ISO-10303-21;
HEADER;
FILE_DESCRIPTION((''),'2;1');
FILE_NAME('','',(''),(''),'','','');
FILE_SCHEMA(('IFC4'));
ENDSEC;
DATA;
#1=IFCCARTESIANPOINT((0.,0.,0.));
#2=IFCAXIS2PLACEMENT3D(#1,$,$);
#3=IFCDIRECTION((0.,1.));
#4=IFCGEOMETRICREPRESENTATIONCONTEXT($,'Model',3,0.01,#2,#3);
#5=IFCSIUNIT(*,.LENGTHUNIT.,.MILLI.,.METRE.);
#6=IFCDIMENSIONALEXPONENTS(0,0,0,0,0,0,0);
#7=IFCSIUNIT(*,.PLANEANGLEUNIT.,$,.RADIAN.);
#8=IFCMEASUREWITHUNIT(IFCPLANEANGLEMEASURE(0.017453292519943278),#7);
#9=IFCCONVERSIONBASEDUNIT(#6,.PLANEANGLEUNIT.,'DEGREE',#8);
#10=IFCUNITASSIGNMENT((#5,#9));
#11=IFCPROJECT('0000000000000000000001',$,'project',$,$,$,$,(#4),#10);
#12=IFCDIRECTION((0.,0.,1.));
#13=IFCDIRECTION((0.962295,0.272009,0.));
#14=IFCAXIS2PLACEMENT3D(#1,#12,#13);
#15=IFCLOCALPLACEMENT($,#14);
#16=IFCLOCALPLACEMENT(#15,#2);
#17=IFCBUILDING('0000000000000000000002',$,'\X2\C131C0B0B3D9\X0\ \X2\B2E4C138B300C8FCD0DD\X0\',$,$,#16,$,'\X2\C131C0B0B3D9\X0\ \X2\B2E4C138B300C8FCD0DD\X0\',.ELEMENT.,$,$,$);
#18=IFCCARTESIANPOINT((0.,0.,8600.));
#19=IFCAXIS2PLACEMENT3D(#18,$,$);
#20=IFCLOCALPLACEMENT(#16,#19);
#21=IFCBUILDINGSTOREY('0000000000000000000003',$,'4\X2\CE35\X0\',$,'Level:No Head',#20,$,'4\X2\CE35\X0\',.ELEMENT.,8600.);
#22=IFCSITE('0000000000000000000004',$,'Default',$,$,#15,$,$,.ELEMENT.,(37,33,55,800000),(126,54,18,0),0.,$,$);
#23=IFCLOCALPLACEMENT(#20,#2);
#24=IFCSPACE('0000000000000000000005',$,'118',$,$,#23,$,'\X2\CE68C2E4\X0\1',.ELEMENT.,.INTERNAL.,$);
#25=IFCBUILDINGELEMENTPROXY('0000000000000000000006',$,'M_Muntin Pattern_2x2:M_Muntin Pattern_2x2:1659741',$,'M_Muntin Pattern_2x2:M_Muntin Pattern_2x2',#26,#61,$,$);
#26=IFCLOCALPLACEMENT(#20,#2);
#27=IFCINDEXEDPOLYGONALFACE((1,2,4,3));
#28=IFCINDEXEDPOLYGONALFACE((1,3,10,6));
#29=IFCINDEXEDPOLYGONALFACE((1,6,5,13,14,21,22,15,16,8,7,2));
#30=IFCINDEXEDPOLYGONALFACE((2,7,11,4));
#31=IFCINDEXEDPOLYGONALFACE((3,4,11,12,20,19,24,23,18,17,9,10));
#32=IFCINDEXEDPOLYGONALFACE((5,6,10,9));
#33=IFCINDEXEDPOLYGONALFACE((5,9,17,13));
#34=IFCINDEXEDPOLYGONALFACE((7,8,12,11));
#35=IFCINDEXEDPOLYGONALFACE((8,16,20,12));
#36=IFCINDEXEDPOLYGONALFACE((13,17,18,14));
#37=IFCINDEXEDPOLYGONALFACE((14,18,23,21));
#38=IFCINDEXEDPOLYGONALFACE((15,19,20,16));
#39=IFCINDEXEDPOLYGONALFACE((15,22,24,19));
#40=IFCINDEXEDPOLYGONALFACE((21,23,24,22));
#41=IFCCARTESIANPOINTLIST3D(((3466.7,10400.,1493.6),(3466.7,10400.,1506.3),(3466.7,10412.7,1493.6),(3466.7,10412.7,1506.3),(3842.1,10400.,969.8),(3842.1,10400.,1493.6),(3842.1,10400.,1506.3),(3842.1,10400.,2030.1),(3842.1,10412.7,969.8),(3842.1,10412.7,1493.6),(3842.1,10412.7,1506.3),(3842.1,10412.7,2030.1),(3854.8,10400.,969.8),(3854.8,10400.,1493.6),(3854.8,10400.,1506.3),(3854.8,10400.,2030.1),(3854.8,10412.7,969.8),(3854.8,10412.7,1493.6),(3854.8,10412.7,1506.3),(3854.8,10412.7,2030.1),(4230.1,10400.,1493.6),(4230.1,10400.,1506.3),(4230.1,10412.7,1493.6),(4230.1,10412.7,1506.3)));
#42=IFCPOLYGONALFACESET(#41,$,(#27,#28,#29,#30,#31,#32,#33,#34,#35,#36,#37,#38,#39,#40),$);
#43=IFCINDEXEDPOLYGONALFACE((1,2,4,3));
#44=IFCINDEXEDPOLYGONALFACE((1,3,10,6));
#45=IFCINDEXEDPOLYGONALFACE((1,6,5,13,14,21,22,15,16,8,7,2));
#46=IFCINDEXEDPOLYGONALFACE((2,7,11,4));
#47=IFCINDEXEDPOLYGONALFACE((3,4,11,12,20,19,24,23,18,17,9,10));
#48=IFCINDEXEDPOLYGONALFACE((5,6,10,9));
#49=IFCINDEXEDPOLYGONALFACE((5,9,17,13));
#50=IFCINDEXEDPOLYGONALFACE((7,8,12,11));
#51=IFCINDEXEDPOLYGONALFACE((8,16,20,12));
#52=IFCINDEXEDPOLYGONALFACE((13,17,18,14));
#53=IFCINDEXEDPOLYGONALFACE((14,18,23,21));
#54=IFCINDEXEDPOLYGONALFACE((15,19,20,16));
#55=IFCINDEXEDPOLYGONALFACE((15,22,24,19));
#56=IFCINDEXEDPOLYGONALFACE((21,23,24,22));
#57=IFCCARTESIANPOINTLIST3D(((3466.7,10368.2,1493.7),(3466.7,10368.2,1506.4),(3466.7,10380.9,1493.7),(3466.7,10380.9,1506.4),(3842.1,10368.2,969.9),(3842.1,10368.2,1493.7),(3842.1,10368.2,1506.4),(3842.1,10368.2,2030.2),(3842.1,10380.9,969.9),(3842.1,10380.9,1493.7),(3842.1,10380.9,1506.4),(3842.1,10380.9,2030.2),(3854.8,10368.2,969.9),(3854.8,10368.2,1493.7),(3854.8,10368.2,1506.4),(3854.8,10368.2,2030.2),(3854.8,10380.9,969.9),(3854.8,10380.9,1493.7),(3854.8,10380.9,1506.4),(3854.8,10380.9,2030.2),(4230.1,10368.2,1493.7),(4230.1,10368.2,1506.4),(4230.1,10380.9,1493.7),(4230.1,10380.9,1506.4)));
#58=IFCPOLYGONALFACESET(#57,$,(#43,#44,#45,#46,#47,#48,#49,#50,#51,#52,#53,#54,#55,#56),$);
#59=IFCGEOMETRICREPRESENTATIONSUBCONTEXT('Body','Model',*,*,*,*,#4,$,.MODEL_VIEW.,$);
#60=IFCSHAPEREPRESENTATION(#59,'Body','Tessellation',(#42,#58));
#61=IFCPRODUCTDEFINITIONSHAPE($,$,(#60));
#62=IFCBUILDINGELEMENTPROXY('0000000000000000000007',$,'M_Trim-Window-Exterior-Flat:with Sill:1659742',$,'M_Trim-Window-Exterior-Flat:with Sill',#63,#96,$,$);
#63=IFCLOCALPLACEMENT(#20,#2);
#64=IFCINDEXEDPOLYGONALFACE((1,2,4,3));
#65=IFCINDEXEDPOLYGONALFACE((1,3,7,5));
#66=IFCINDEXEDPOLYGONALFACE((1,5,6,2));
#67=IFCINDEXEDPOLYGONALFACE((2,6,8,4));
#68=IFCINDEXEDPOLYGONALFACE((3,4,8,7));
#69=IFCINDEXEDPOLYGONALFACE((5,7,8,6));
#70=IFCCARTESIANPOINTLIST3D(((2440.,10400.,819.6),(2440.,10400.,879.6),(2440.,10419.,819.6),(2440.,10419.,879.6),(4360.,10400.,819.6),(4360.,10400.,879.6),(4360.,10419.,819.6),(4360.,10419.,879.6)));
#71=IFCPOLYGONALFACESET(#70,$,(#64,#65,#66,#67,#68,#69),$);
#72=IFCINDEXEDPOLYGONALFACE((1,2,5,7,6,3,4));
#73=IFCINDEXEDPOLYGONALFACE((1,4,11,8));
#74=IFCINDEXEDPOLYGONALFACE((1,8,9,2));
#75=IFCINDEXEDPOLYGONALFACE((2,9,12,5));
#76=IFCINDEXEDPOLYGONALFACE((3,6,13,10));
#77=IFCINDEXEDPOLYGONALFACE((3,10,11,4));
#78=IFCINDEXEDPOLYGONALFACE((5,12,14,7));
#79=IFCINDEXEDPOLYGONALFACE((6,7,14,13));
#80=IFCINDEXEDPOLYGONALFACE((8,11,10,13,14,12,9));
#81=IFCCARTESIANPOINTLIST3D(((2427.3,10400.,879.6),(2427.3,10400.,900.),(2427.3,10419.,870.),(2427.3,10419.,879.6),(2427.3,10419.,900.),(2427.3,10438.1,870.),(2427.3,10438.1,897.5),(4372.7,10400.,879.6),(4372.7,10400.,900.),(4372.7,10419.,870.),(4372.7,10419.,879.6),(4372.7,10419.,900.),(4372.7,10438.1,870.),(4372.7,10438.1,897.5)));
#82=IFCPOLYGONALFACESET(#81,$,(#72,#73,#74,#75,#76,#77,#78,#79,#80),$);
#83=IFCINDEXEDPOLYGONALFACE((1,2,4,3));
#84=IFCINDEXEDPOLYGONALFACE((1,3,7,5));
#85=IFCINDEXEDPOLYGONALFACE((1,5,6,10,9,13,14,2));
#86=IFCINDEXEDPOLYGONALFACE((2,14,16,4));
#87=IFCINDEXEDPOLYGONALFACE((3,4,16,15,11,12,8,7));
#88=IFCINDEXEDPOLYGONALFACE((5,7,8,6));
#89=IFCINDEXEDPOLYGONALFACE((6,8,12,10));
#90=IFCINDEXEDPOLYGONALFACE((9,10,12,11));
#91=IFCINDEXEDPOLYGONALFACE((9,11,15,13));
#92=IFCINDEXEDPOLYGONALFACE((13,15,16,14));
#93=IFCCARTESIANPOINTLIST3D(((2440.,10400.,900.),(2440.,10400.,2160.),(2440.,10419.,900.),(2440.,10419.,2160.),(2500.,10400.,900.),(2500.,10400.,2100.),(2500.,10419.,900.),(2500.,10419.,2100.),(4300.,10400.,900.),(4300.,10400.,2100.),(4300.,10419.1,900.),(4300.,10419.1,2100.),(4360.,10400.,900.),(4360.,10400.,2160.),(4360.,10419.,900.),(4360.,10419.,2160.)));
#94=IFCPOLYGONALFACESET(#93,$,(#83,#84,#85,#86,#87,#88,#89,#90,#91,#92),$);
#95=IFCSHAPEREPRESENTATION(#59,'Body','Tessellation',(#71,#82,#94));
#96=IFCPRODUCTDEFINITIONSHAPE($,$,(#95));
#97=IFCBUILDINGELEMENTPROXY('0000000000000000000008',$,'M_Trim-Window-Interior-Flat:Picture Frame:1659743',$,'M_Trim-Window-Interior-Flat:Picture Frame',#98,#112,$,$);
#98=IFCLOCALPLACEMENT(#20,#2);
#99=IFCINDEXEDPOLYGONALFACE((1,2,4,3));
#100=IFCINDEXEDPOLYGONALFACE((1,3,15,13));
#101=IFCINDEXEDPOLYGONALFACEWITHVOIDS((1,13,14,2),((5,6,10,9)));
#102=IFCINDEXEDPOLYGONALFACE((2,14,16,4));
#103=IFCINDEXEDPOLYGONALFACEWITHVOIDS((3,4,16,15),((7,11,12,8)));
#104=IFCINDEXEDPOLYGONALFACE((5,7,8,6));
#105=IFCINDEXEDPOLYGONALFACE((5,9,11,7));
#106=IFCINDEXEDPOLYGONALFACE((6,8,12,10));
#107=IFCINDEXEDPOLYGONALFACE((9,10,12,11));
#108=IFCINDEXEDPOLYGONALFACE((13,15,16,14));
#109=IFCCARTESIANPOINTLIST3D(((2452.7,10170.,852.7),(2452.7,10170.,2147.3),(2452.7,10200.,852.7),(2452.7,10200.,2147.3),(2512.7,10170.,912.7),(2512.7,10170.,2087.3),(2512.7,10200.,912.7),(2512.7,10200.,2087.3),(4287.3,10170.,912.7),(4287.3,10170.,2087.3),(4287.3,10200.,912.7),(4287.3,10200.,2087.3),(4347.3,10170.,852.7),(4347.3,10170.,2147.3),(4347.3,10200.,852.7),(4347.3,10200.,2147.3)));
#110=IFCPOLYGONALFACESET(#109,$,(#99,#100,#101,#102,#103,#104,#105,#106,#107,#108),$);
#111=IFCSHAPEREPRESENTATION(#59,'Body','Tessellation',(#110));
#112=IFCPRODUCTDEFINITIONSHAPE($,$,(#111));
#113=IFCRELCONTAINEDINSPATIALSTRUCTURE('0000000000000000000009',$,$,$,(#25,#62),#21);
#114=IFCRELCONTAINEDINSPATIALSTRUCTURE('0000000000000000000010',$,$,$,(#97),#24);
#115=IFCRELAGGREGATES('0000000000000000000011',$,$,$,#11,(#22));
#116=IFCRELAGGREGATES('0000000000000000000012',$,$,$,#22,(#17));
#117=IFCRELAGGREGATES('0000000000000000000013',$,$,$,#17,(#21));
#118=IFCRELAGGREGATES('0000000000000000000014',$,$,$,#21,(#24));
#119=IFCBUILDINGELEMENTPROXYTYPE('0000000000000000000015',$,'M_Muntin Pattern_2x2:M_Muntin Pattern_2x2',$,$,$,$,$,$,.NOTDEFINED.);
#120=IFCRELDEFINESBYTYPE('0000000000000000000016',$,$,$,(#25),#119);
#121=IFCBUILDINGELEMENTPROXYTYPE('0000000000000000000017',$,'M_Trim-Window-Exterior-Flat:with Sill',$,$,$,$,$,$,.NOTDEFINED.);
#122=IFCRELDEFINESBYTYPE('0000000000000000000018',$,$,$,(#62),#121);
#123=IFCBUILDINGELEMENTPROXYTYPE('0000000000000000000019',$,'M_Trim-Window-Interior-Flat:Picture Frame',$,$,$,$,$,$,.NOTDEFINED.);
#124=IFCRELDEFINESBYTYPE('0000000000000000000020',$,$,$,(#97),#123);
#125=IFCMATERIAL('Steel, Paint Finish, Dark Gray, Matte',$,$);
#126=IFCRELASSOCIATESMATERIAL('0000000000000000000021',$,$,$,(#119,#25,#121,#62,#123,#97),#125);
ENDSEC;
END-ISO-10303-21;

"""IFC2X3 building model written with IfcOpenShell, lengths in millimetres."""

from ifc_helpers import new_model, entity, si_unit, converted_unit, direction, frame, frame_2d, origin, place, context, subcontext, project, spatial, polyline, rectangle, outline, extrude, source, transform, mapped, material, type_object, type_shapes, element, save


model = new_model("IFC2X3")

# Units and contexts
model_context = context("Model", 3, precision=0.01, world=origin(), true_north=direction((0.0, 1.0)))
body_context = subcontext(model_context, "Body", "Model", "MODEL_VIEW")
ifc_project = project(units=[si_unit("LENGTHUNIT", "METRE", prefix="MILLI"), converted_unit("PLANEANGLEUNIT", "DEGREE", entity("IfcPlaneAngleMeasure", 0.017453292519943278), si_unit("PLANEANGLEUNIT", "RADIAN"), dimensions=[0, 0, 0, 0, 0, 0, 0])], contexts=[model_context])

# Site, building, storey
site_placement = place(None, frame((0.0, 0.0, 0.0), z_axis=(0.0, 0.0, 1.0), x_axis=(0.962295, 0.272009, 0.0)))
site = spatial("IfcSite", under=ifc_project, at=site_placement, Name="Default", CompositionType="ELEMENT", RefLatitude=(37, 33, 55, 800000), RefLongitude=(126, 54, 18, 0), RefElevation=0.0)
building_placement = place(site_placement, origin())
building = spatial("IfcBuilding", under=site, at=building_placement, Name="성산동 다세대주택", LongName="성산동 다세대주택", CompositionType="ELEMENT")
storey_placement = place(building_placement, frame((0.0, 0.0, 8600.0)))
storey = spatial("IfcBuildingStorey", under=building, at=storey_placement, Name="4층", ObjectType="Level:No Head", LongName="4층", CompositionType="ELEMENT", Elevation=8600.0)

# Shared definitions
space_1_placement = place(storey_placement, origin())
space_1 = spatial("IfcSpace", under=storey, at=space_1_placement, Name="118", LongName="침실1", CompositionType="ELEMENT", InteriorOrExteriorSpace="INTERNAL")

# Building element proxies
ifc_material_1 = material(Name="Steel, Paint Finish, Dark Gray, Matte")
building_element_proxy_type_1 = type_object("IfcBuildingElementProxyType", Name="M_Muntin Pattern_2x2:M_Muntin Pattern_2x2", PredefinedType="NOTDEFINED", material=ifc_material_1)
shared_shape_1 = source(origin(), body_context, "Body", "SweptSolid", [
    extrude(outline(polyline([(6.4, -6.4), (530.1, -6.4), (530.1, 6.3), (6.4, 6.3), (6.4, 381.7), (-6.3, 381.7), (-6.3, 6.3), (-530.2, 6.3), (-530.2, -6.4), (-6.3, -6.4), (-6.3, -381.7), (6.4, -381.7), (6.4, -6.4)])), frame((0.0, -22.2, 530.1), z_axis=(0.0, 1.0, 0.0), x_axis=(0.0, 0.0, 1.0)), (0.0, 0.0, 1.0), 12.7),
    extrude(outline(polyline([(6.4, -6.4), (530.2, -6.4), (530.2, 6.3), (6.4, 6.3), (6.4, 381.7), (-6.3, 381.7), (-6.3, 6.3), (-530.2, 6.3), (-530.2, -6.4), (-6.3, -6.4), (-6.3, -381.7), (6.4, -381.7), (6.4, -6.4)])), frame((0.0, 9.5, 530.2), z_axis=(0.0, 1.0, 0.0), x_axis=(0.0, 0.0, 1.0)), (0.0, 0.0, 1.0), 12.7),
])
type_shapes(building_element_proxy_type_1, [shared_shape_1])
proxy_1_placement = place(storey_placement, frame((3848.4, 10390.5, 969.9), z_axis=(0.0, 0.0, 1.0), x_axis=(-1.0, 0.0, 0.0)))
element("IfcBuildingElementProxy", 1, at=proxy_1_placement, inside=storey, type_object=building_element_proxy_type_1, material=ifc_material_1, Name="M_Muntin Pattern_2x2:M_Muntin Pattern_2x2:1659741", ObjectType="M_Muntin Pattern_2x2:M_Muntin Pattern_2x2", context=body_context, shape_type="MappedRepresentation", body=[
    mapped(shared_shape_1, transform((0.0, 0.0, 0.0), scale=1.0)),
])
building_element_proxy_type_2 = type_object("IfcBuildingElementProxyType", Name="M_Trim-Window-Exterior-Flat:with Sill", PredefinedType="NOTDEFINED", material=ifc_material_1)
shared_shape_2 = source(origin(), body_context, "Body", "SweptSolid", [
    extrude(rectangle(XDim=1920.0, YDim=60.0, at=frame_2d((0.0, 0.0), x_axis=(1.0, 0.0))), frame((0.0, -1250.4, 0.0), z_axis=(0.0, 0.0, 1.0), x_axis=(-1.0, 0.0, 0.0)), (0.0, 0.0, 1.0), 19.0),
    extrude(outline(polyline([(-19.0, -15.2), (0.0, -15.2), (0.0, -5.7), (19.0, -5.7), (19.0, 14.8), (0.0, 14.8), (-19.0, 12.3), (-19.0, -15.2)])), frame((-972.7, -1214.8, 19.0), z_axis=(1.0, 0.0, 0.0), x_axis=(0.0, 0.0, -1.0)), (0.0, 0.0, 1.0), 1945.4),
    extrude(outline(polyline([(-645.0, -960.0), (615.0, -960.0), (615.0, -900.0), (-585.0, -900.0), (-585.0, 900.0), (615.0, 900.0), (615.0, 960.0), (-645.0, 960.0), (-645.0, -960.0)])), frame((0.0, -585.0, 0.0), z_axis=(0.0, 0.0, 1.0), x_axis=(0.0, -1.0, 0.0)), (0.0, 0.0, 1.0), 19.0),
])
type_shapes(building_element_proxy_type_2, [shared_shape_2])
proxy_2_placement = place(storey_placement, frame((3400.0, 10400.0, 2100.0), z_axis=(0.0, 1.0, 0.0), x_axis=(-1.0, 0.0, 0.0)))
element("IfcBuildingElementProxy", 2, at=proxy_2_placement, inside=storey, type_object=building_element_proxy_type_2, material=ifc_material_1, Name="M_Trim-Window-Exterior-Flat:with Sill:1659742", ObjectType="M_Trim-Window-Exterior-Flat:with Sill", context=body_context, shape_type="MappedRepresentation", body=[
    mapped(shared_shape_2, transform((0.0, 0.0, 0.0), scale=1.0)),
])
building_element_proxy_type_3 = type_object("IfcBuildingElementProxyType", Name="M_Trim-Window-Interior-Flat:Picture Frame", PredefinedType="NOTDEFINED", material=ifc_material_1)
shared_shape_3 = source(origin(), body_context, "Body", "SweptSolid", [
    extrude(outline(polyline([(-947.3, -647.3), (947.3, -647.3), (947.3, 647.3), (-947.3, 647.3), (-947.3, -647.3)]), holes=[polyline([(-887.3, -587.3), (-887.3, 587.3), (887.3, 587.3), (887.3, -587.3), (-887.3, -587.3)])]), frame((0.0, -600.0, 0.0), z_axis=(0.0, 0.0, 1.0), x_axis=(-1.0, 0.0, 0.0)), (0.0, 0.0, 1.0), 30.0),
])
type_shapes(building_element_proxy_type_3, [shared_shape_3])
proxy_3_placement = place(space_1_placement, frame((3400.0, 10200.0, 2100.0), z_axis=(0.0, -1.0, 0.0), x_axis=(1.0, 0.0, 0.0)))
element("IfcBuildingElementProxy", 3, at=proxy_3_placement, inside=space_1, type_object=building_element_proxy_type_3, material=ifc_material_1, Name="M_Trim-Window-Interior-Flat:Picture Frame:1659743", ObjectType="M_Trim-Window-Interior-Flat:Picture Frame", context=body_context, shape_type="MappedRepresentation", body=[
    mapped(shared_shape_3, transform((0.0, 0.0, 0.0), scale=1.0)),
])

save(model, "model.ifc")
